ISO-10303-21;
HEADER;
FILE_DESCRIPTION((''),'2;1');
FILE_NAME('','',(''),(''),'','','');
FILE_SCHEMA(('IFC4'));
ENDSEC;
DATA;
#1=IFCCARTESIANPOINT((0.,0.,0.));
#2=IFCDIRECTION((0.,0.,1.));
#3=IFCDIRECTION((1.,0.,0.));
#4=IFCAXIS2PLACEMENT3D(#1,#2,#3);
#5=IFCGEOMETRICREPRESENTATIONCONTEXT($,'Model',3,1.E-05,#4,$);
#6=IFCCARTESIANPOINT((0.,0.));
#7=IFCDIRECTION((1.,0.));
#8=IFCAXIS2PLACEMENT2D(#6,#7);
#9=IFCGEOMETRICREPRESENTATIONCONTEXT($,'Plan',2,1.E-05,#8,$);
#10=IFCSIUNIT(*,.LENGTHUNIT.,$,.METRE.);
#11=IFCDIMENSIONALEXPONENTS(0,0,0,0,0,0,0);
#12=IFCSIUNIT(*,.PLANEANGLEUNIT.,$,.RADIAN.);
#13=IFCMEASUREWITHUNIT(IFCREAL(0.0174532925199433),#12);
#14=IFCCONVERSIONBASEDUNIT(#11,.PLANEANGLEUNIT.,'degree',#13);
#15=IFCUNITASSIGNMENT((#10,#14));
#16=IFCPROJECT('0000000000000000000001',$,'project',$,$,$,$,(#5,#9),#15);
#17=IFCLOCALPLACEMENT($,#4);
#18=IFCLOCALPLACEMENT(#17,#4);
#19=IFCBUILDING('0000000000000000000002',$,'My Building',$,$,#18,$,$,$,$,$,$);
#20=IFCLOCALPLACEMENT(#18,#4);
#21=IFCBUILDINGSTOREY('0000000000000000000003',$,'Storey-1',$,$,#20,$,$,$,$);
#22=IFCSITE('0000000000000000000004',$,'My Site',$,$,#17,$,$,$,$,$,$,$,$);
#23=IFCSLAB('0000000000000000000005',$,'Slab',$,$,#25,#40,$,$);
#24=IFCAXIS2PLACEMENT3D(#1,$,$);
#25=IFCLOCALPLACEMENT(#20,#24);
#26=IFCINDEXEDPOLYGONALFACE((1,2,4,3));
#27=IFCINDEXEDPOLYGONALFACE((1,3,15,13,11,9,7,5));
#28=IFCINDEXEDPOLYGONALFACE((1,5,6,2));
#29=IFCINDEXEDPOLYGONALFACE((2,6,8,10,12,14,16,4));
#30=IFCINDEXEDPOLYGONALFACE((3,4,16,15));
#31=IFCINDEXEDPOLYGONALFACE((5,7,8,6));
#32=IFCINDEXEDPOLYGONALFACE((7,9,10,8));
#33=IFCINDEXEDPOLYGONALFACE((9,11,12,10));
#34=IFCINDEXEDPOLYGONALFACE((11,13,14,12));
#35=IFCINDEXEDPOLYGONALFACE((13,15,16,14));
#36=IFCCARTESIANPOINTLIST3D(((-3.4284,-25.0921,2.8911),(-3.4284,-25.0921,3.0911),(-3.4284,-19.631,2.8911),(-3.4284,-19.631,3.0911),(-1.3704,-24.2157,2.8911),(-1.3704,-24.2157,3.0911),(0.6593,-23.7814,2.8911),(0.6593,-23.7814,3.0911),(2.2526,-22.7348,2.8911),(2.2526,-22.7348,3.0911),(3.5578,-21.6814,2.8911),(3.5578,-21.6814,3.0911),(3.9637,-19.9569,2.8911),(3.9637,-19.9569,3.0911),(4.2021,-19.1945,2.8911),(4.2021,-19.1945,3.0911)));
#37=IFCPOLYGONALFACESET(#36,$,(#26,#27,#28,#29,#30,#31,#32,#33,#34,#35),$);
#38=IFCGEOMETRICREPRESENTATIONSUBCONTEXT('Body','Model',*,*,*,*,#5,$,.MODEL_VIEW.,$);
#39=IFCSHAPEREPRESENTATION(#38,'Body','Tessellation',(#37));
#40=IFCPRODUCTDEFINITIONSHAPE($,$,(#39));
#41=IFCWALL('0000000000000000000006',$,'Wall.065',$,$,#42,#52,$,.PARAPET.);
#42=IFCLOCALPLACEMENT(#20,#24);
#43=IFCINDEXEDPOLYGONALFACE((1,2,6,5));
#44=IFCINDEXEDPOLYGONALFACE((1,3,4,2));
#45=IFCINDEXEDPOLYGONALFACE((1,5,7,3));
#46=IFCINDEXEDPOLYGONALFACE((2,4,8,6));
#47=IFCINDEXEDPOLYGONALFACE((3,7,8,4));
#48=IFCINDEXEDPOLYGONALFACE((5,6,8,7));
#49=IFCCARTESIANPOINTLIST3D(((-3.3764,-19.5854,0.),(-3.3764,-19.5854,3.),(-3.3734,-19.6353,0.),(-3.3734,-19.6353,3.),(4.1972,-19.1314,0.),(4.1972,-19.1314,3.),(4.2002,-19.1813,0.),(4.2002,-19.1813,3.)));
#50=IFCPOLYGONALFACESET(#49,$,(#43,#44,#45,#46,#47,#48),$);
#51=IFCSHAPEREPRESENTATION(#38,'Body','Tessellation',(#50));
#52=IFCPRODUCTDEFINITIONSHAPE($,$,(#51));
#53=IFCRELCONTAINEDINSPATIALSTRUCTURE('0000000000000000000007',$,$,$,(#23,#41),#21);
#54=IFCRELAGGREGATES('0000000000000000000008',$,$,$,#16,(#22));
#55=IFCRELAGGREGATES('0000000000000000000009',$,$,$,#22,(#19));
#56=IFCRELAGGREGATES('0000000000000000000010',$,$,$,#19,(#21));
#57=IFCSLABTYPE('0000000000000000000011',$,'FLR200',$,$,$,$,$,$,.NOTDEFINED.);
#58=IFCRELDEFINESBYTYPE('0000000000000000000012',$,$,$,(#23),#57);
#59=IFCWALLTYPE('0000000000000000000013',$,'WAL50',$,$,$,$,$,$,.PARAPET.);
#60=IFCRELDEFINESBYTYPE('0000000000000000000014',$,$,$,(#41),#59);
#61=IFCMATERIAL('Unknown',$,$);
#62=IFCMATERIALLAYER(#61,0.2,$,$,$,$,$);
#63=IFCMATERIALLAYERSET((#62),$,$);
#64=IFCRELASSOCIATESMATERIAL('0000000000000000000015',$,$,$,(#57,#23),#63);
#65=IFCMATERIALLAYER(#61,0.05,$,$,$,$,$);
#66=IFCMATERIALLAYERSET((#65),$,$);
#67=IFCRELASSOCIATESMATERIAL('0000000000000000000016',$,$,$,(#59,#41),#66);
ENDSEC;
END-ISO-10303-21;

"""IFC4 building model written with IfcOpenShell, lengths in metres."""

from ifc_helpers import new_model, entity, si_unit, converted_unit, frame, origin_with_axes, origin_2d_with_axis, place, context, subcontext, project, spatial, indexed_curve, outline, extrude, material, layer, layer_set, layer_usage, type_object, element, save


model = new_model("IFC4")

# Units and contexts
model_context = context("Model", 3, precision=1e-05, world=origin_with_axes())
plan_context = context("Plan", 2, precision=1e-05, world=origin_2d_with_axis())
body_context = subcontext(model_context, "Body", "Model", "MODEL_VIEW")
ifc_project = project(units=[si_unit("LENGTHUNIT", "METRE"), converted_unit("PLANEANGLEUNIT", "degree", entity("IfcReal", 0.0174532925199433), si_unit("PLANEANGLEUNIT", "RADIAN"), dimensions=[0, 0, 0, 0, 0, 0, 0])], contexts=[model_context, plan_context])

# Site, building, storey
site_placement = place(None, origin_with_axes())
site = spatial("IfcSite", under=ifc_project, at=site_placement, Name="My Site")
building_placement = place(site_placement, origin_with_axes())
building = spatial("IfcBuilding", under=site, at=building_placement, Name="My Building")
storey_placement = place(building_placement, origin_with_axes())
storey = spatial("IfcBuildingStorey", under=building, at=storey_placement, Name="Storey-1")

# Slab
ifc_material = material(Name="Unknown")
ifc_layer_1 = layer(ifc_material, 0.2)
ifc_layer_set_1 = layer_set([ifc_layer_1])
ifc_layer_usage_1 = layer_usage(ifc_layer_set_1, "AXIS3", "POSITIVE", -0.2)
slab_type = type_object("IfcSlabType", Name="FLR200", PredefinedType="NOTDEFINED", material=ifc_layer_set_1)
slab_placement = place(storey_placement, frame((-3.4284, -19.631, 3.0911), z_axis=(0.0, 0.0, 1.0), x_axis=(1.0, 0.0, 0.0)))
element("IfcSlab", 1, at=slab_placement, inside=storey, type_object=slab_type, material=ifc_layer_usage_1, Name="Slab", context=body_context, shape_type="SweptSolid", body=[
    extrude(outline(indexed_curve([(0.0, 0.0), (0.0, -5.461), (2.058, -4.5847), (4.0877, -4.1503), (5.681, -3.1037), (6.9862, -2.0503), (7.3921, -0.3259), (7.6306, 0.4365), (0.0, 0.0)])), frame((0.0, 0.0, -0.2), z_axis=(0.0, 0.0, 1.0), x_axis=(1.0, 0.0, 0.0)), (0.0, 0.0, 1.0), 0.2),
])

# Wall
ifc_layer_2 = layer(ifc_material, 0.05)
ifc_layer_set_2 = layer_set([ifc_layer_2])
wall_type = type_object("IfcWallType", Name="WAL50", PredefinedType="PARAPET", material=ifc_layer_set_2)
ifc_layer_usage_2 = layer_usage(ifc_layer_set_2, "AXIS2", "POSITIVE", 0.0)
wall_1_placement = place(storey_placement, frame((-3.3734, -19.6353, 0.0), z_axis=(0.0, 0.0, 1.0), x_axis=(0.998208, 0.059832, 0.0)))
element("IfcWall", 2, at=wall_1_placement, inside=storey, type_object=wall_type, material=ifc_layer_usage_2, Name="Wall.065", PredefinedType="PARAPET", context=body_context, shape_type="SweptSolid", body=[
    extrude(outline(indexed_curve([(0.0, 0.0), (0.0, 0.05), (7.5872, 0.05), (7.5872, 0.0), (0.0, 0.0)], self_intersect=False)), origin_with_axes(), (0.0, 0.0, 1.0), 3.0),
])

save(model, "model.ifc")
